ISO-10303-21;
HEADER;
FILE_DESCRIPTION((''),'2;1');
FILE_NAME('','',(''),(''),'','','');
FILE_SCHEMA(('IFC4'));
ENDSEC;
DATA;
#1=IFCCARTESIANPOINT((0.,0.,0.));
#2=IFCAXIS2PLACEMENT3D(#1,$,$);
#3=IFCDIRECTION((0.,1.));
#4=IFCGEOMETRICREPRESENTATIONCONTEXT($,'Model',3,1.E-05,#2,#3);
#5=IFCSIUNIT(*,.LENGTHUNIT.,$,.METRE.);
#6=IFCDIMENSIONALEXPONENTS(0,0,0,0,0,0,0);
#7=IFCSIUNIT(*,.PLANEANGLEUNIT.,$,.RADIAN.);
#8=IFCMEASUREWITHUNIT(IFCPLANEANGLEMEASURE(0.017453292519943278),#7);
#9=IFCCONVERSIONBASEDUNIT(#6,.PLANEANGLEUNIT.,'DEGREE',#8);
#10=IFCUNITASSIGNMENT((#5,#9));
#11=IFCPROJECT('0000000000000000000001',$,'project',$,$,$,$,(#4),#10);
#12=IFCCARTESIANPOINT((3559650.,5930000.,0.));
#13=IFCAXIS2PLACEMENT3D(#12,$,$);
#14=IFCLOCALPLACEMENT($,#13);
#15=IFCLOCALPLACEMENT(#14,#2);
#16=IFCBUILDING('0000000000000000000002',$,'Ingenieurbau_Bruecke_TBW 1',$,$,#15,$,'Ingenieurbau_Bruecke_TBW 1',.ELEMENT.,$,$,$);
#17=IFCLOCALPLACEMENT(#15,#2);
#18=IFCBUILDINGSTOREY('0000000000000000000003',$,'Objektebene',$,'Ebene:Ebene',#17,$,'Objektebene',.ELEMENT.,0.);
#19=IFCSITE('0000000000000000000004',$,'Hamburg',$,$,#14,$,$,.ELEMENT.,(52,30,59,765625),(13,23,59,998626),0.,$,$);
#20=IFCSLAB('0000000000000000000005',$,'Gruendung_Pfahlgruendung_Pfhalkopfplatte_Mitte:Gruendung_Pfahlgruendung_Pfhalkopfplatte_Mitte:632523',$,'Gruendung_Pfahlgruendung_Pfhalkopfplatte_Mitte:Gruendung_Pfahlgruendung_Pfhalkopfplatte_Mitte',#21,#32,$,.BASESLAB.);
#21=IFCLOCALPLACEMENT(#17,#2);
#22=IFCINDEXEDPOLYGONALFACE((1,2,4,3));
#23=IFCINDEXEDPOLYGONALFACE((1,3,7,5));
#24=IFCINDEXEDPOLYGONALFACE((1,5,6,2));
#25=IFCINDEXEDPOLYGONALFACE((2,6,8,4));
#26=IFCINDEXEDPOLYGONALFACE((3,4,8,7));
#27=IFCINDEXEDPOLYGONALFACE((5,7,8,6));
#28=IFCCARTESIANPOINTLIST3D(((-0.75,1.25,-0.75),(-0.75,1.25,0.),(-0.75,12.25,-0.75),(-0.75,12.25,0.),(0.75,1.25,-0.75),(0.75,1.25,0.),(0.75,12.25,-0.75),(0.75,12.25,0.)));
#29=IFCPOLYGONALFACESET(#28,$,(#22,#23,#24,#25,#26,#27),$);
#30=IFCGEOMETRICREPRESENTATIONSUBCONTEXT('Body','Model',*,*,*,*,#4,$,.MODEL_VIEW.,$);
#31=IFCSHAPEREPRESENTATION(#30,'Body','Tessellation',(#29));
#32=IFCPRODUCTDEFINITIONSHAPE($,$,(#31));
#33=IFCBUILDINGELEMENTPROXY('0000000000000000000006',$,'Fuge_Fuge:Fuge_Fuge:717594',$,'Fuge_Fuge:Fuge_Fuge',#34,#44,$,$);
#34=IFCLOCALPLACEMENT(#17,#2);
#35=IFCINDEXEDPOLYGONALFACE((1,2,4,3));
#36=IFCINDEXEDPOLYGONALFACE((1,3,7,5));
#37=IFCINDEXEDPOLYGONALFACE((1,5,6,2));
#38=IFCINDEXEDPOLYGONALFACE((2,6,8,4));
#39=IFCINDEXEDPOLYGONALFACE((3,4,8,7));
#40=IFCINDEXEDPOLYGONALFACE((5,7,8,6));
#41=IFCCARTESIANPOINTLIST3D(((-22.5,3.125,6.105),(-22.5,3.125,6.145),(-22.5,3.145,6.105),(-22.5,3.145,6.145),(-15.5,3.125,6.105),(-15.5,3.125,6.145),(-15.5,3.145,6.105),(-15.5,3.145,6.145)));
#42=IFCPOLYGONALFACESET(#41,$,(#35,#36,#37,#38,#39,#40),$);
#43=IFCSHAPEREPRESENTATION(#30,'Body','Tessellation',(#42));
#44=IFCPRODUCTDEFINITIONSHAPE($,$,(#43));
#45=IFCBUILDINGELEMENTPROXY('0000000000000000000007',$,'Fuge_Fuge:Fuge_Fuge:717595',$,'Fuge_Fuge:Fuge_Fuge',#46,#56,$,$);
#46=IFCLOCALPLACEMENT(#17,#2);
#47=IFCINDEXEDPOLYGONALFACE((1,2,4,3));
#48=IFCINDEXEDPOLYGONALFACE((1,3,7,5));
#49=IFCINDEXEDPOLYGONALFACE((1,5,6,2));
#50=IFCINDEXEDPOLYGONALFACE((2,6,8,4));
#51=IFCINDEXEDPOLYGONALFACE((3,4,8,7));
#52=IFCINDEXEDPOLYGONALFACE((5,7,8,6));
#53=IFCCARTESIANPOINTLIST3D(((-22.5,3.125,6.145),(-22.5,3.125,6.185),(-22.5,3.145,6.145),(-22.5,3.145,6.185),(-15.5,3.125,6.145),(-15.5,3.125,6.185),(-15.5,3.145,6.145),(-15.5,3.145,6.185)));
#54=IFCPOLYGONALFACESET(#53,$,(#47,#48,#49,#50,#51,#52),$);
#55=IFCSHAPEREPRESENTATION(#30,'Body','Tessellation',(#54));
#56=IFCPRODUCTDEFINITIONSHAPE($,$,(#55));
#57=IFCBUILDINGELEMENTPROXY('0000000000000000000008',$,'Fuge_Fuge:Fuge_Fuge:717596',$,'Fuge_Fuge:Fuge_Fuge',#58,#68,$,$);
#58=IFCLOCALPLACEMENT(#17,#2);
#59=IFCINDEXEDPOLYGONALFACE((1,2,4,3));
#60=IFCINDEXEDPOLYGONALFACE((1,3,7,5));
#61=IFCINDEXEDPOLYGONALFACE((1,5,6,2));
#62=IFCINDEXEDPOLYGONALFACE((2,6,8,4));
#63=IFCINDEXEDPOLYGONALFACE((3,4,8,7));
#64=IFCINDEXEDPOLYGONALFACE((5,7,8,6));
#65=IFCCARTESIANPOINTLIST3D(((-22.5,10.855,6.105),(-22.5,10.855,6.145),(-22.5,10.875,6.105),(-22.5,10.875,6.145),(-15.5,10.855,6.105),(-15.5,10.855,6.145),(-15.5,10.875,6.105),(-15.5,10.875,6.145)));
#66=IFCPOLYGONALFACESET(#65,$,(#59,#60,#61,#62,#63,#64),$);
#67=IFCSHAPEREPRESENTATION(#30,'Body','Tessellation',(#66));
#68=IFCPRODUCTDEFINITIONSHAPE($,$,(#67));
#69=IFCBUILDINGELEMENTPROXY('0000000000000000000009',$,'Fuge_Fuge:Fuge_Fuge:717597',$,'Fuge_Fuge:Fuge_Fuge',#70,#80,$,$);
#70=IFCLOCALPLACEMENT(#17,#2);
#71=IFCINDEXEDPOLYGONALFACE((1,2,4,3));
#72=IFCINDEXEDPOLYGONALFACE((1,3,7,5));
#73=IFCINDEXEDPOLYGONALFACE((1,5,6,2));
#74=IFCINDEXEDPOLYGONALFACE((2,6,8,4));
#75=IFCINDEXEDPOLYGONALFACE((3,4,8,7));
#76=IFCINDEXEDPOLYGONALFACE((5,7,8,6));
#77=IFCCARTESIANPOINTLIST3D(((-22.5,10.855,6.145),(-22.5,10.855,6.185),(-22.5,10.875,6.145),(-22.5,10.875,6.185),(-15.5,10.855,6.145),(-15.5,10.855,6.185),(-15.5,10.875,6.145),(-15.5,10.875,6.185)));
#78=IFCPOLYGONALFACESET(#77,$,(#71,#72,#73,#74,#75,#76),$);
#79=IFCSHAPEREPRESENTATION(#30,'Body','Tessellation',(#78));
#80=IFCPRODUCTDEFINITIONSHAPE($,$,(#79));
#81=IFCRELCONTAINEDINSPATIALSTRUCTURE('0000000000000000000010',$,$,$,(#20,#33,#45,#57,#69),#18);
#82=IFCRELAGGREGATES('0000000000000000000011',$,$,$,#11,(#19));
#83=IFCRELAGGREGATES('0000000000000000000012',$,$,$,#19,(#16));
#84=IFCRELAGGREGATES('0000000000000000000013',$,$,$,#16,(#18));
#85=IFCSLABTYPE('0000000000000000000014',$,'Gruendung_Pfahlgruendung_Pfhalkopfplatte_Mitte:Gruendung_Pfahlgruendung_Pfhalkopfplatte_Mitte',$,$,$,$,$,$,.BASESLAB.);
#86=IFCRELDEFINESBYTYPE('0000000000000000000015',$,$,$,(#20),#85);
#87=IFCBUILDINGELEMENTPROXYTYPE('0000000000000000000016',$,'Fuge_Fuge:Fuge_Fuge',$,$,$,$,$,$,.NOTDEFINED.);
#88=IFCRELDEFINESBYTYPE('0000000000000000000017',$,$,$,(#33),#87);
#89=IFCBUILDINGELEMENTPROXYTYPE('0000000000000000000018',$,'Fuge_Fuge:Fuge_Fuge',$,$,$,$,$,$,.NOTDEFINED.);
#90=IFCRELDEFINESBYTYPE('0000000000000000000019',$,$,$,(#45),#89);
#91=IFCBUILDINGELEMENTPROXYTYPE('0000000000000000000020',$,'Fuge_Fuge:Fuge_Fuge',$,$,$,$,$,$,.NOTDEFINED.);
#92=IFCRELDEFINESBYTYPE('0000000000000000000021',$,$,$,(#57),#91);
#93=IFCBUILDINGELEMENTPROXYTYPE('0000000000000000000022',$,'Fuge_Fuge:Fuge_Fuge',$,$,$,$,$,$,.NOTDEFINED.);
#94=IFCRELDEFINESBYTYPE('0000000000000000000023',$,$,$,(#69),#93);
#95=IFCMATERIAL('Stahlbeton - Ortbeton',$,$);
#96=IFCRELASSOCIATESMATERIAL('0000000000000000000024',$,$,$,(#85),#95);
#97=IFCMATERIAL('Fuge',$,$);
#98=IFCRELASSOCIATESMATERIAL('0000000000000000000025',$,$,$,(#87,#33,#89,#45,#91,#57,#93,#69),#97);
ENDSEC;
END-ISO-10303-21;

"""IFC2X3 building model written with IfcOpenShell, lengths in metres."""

from ifc_helpers import new_model, entity, si_unit, converted_unit, direction, frame, frame_2d, origin, origin_2d_with_axis, place, context, subcontext, project, spatial, rectangle, extrude, source, transform, mapped, material, type_object, type_shapes, element, save


model = new_model("IFC2X3")

# Units and contexts
model_context = context("Model", 3, precision=1e-05, world=origin(), true_north=direction((0.0, 1.0)))
body_context = subcontext(model_context, "Body", "Model", "MODEL_VIEW")
ifc_project = project(units=[si_unit("LENGTHUNIT", "METRE"), converted_unit("PLANEANGLEUNIT", "DEGREE", entity("IfcPlaneAngleMeasure", 0.017453292519943278), si_unit("PLANEANGLEUNIT", "RADIAN"), dimensions=[0, 0, 0, 0, 0, 0, 0])], contexts=[model_context])

# Site, building, storey
site_placement = place(None, frame((3559650.0, 5930000.0, 0.0)))
site = spatial("IfcSite", under=ifc_project, at=site_placement, Name="Hamburg", CompositionType="ELEMENT", RefLatitude=(52, 30, 59, 765625), RefLongitude=(13, 23, 59, 998626), RefElevation=0.0)
building_placement = place(site_placement, origin())
building = spatial("IfcBuilding", under=site, at=building_placement, Name="Ingenieurbau_Bruecke_TBW 1", LongName="Ingenieurbau_Bruecke_TBW 1", CompositionType="ELEMENT")
storey_placement = place(building_placement, origin())
storey = spatial("IfcBuildingStorey", under=building, at=storey_placement, Name="Objektebene", ObjectType="Ebene:Ebene", LongName="Objektebene", CompositionType="ELEMENT", Elevation=0.0)

# Slab
ifc_material_1 = material(Name="Stahlbeton - Ortbeton")
slab_type_1 = type_object("IfcSlabType", Name="Gruendung_Pfahlgruendung_Pfhalkopfplatte_Mitte:Gruendung_Pfahlgruendung_Pfhalkopfplatte_Mitte", PredefinedType="BASESLAB", material=ifc_material_1)
slab_1_placement = place(storey_placement, origin())
element("IfcSlab", 1, at=slab_1_placement, inside=storey, type_object=slab_type_1, Name="Gruendung_Pfahlgruendung_Pfhalkopfplatte_Mitte:Gruendung_Pfahlgruendung_Pfhalkopfplatte_Mitte:632523", ObjectType="Gruendung_Pfahlgruendung_Pfhalkopfplatte_Mitte:Gruendung_Pfahlgruendung_Pfhalkopfplatte_Mitte", PredefinedType="BASESLAB", context=body_context, shape_type="SweptSolid", body=[
    extrude(rectangle(XDim=1.5, YDim=11.0, at=origin_2d_with_axis()), frame((0.0, 6.75, -0.75), z_axis=(0.0, 0.0, 1.0), x_axis=(-1.0, 0.0, 0.0)), (0.0, 0.0, 1.0), 0.75),
])

# Building element proxies
ifc_material_2 = material(Name="Fuge")
building_element_proxy_type_1 = type_object("IfcBuildingElementProxyType", Name="Fuge_Fuge:Fuge_Fuge", PredefinedType="NOTDEFINED", material=ifc_material_2)
shared_shape_1 = source(origin(), body_context, "Body", "SweptSolid", [
    extrude(rectangle(XDim=0.02, YDim=7.0, at=frame_2d((0.0, 0.0), x_axis=(1.0, 0.0))), frame((-19.0, 3.135, 6.105), z_axis=(0.0, 0.0, 1.0), x_axis=(0.0, -1.0, 0.0)), (0.0, 0.0, 1.0), 0.04),
])
type_shapes(building_element_proxy_type_1, [shared_shape_1])
proxy_1_placement = place(storey_placement, origin())
element("IfcBuildingElementProxy", 2, at=proxy_1_placement, inside=storey, type_object=building_element_proxy_type_1, material=ifc_material_2, Name="Fuge_Fuge:Fuge_Fuge:717594", ObjectType="Fuge_Fuge:Fuge_Fuge", context=body_context, shape_type="MappedRepresentation", body=[
    mapped(shared_shape_1, transform((0.0, 0.0, 0.0), scale=1.0)),
])
building_element_proxy_type_2 = type_object("IfcBuildingElementProxyType", Name="Fuge_Fuge:Fuge_Fuge", PredefinedType="NOTDEFINED", material=ifc_material_2)
shared_shape_2 = source(origin(), body_context, "Body", "SweptSolid", [
    extrude(rectangle(XDim=0.02, YDim=7.0, at=frame_2d((0.0, 0.0), x_axis=(1.0, 0.0))), frame((-19.0, 3.135, 6.145), z_axis=(0.0, 0.0, 1.0), x_axis=(0.0, -1.0, 0.0)), (0.0, 0.0, 1.0), 0.04),
])
type_shapes(building_element_proxy_type_2, [shared_shape_2])
proxy_2_placement = place(storey_placement, origin())
element("IfcBuildingElementProxy", 3, at=proxy_2_placement, inside=storey, type_object=building_element_proxy_type_2, material=ifc_material_2, Name="Fuge_Fuge:Fuge_Fuge:717595", ObjectType="Fuge_Fuge:Fuge_Fuge", context=body_context, shape_type="MappedRepresentation", body=[
    mapped(shared_shape_2, transform((0.0, 0.0, 0.0), scale=1.0)),
])
building_element_proxy_type_3 = type_object("IfcBuildingElementProxyType", Name="Fuge_Fuge:Fuge_Fuge", PredefinedType="NOTDEFINED", material=ifc_material_2)
shared_shape_3 = source(origin(), body_context, "Body", "SweptSolid", [
    extrude(rectangle(XDim=0.02, YDim=7.0, at=frame_2d((0.0, 0.0), x_axis=(1.0, 0.0))), frame((-19.0, 10.865, 6.105), z_axis=(0.0, 0.0, 1.0), x_axis=(0.0, -1.0, 0.0)), (0.0, 0.0, 1.0), 0.04),
])
type_shapes(building_element_proxy_type_3, [shared_shape_3])
proxy_3_placement = place(storey_placement, origin())
element("IfcBuildingElementProxy", 4, at=proxy_3_placement, inside=storey, type_object=building_element_proxy_type_3, material=ifc_material_2, Name="Fuge_Fuge:Fuge_Fuge:717596", ObjectType="Fuge_Fuge:Fuge_Fuge", context=body_context, shape_type="MappedRepresentation", body=[
    mapped(shared_shape_3, transform((0.0, 0.0, 0.0), scale=1.0)),
])
building_element_proxy_type_4 = type_object("IfcBuildingElementProxyType", Name="Fuge_Fuge:Fuge_Fuge", PredefinedType="NOTDEFINED", material=ifc_material_2)
shared_shape_4 = source(origin(), body_context, "Body", "SweptSolid", [
    extrude(rectangle(XDim=0.02, YDim=7.0, at=frame_2d((0.0, 0.0), x_axis=(1.0, 0.0))), frame((-19.0, 10.865, 6.145), z_axis=(0.0, 0.0, 1.0), x_axis=(0.0, -1.0, 0.0)), (0.0, 0.0, 1.0), 0.04),
])
type_shapes(building_element_proxy_type_4, [shared_shape_4])
proxy_4_placement = place(storey_placement, origin())
element("IfcBuildingElementProxy", 5, at=proxy_4_placement, inside=storey, type_object=building_element_proxy_type_4, material=ifc_material_2, Name="Fuge_Fuge:Fuge_Fuge:717597", ObjectType="Fuge_Fuge:Fuge_Fuge", context=body_context, shape_type="MappedRepresentation", body=[
    mapped(shared_shape_4, transform((0.0, 0.0, 0.0), scale=1.0)),
])

save(model, "model.ifc")
